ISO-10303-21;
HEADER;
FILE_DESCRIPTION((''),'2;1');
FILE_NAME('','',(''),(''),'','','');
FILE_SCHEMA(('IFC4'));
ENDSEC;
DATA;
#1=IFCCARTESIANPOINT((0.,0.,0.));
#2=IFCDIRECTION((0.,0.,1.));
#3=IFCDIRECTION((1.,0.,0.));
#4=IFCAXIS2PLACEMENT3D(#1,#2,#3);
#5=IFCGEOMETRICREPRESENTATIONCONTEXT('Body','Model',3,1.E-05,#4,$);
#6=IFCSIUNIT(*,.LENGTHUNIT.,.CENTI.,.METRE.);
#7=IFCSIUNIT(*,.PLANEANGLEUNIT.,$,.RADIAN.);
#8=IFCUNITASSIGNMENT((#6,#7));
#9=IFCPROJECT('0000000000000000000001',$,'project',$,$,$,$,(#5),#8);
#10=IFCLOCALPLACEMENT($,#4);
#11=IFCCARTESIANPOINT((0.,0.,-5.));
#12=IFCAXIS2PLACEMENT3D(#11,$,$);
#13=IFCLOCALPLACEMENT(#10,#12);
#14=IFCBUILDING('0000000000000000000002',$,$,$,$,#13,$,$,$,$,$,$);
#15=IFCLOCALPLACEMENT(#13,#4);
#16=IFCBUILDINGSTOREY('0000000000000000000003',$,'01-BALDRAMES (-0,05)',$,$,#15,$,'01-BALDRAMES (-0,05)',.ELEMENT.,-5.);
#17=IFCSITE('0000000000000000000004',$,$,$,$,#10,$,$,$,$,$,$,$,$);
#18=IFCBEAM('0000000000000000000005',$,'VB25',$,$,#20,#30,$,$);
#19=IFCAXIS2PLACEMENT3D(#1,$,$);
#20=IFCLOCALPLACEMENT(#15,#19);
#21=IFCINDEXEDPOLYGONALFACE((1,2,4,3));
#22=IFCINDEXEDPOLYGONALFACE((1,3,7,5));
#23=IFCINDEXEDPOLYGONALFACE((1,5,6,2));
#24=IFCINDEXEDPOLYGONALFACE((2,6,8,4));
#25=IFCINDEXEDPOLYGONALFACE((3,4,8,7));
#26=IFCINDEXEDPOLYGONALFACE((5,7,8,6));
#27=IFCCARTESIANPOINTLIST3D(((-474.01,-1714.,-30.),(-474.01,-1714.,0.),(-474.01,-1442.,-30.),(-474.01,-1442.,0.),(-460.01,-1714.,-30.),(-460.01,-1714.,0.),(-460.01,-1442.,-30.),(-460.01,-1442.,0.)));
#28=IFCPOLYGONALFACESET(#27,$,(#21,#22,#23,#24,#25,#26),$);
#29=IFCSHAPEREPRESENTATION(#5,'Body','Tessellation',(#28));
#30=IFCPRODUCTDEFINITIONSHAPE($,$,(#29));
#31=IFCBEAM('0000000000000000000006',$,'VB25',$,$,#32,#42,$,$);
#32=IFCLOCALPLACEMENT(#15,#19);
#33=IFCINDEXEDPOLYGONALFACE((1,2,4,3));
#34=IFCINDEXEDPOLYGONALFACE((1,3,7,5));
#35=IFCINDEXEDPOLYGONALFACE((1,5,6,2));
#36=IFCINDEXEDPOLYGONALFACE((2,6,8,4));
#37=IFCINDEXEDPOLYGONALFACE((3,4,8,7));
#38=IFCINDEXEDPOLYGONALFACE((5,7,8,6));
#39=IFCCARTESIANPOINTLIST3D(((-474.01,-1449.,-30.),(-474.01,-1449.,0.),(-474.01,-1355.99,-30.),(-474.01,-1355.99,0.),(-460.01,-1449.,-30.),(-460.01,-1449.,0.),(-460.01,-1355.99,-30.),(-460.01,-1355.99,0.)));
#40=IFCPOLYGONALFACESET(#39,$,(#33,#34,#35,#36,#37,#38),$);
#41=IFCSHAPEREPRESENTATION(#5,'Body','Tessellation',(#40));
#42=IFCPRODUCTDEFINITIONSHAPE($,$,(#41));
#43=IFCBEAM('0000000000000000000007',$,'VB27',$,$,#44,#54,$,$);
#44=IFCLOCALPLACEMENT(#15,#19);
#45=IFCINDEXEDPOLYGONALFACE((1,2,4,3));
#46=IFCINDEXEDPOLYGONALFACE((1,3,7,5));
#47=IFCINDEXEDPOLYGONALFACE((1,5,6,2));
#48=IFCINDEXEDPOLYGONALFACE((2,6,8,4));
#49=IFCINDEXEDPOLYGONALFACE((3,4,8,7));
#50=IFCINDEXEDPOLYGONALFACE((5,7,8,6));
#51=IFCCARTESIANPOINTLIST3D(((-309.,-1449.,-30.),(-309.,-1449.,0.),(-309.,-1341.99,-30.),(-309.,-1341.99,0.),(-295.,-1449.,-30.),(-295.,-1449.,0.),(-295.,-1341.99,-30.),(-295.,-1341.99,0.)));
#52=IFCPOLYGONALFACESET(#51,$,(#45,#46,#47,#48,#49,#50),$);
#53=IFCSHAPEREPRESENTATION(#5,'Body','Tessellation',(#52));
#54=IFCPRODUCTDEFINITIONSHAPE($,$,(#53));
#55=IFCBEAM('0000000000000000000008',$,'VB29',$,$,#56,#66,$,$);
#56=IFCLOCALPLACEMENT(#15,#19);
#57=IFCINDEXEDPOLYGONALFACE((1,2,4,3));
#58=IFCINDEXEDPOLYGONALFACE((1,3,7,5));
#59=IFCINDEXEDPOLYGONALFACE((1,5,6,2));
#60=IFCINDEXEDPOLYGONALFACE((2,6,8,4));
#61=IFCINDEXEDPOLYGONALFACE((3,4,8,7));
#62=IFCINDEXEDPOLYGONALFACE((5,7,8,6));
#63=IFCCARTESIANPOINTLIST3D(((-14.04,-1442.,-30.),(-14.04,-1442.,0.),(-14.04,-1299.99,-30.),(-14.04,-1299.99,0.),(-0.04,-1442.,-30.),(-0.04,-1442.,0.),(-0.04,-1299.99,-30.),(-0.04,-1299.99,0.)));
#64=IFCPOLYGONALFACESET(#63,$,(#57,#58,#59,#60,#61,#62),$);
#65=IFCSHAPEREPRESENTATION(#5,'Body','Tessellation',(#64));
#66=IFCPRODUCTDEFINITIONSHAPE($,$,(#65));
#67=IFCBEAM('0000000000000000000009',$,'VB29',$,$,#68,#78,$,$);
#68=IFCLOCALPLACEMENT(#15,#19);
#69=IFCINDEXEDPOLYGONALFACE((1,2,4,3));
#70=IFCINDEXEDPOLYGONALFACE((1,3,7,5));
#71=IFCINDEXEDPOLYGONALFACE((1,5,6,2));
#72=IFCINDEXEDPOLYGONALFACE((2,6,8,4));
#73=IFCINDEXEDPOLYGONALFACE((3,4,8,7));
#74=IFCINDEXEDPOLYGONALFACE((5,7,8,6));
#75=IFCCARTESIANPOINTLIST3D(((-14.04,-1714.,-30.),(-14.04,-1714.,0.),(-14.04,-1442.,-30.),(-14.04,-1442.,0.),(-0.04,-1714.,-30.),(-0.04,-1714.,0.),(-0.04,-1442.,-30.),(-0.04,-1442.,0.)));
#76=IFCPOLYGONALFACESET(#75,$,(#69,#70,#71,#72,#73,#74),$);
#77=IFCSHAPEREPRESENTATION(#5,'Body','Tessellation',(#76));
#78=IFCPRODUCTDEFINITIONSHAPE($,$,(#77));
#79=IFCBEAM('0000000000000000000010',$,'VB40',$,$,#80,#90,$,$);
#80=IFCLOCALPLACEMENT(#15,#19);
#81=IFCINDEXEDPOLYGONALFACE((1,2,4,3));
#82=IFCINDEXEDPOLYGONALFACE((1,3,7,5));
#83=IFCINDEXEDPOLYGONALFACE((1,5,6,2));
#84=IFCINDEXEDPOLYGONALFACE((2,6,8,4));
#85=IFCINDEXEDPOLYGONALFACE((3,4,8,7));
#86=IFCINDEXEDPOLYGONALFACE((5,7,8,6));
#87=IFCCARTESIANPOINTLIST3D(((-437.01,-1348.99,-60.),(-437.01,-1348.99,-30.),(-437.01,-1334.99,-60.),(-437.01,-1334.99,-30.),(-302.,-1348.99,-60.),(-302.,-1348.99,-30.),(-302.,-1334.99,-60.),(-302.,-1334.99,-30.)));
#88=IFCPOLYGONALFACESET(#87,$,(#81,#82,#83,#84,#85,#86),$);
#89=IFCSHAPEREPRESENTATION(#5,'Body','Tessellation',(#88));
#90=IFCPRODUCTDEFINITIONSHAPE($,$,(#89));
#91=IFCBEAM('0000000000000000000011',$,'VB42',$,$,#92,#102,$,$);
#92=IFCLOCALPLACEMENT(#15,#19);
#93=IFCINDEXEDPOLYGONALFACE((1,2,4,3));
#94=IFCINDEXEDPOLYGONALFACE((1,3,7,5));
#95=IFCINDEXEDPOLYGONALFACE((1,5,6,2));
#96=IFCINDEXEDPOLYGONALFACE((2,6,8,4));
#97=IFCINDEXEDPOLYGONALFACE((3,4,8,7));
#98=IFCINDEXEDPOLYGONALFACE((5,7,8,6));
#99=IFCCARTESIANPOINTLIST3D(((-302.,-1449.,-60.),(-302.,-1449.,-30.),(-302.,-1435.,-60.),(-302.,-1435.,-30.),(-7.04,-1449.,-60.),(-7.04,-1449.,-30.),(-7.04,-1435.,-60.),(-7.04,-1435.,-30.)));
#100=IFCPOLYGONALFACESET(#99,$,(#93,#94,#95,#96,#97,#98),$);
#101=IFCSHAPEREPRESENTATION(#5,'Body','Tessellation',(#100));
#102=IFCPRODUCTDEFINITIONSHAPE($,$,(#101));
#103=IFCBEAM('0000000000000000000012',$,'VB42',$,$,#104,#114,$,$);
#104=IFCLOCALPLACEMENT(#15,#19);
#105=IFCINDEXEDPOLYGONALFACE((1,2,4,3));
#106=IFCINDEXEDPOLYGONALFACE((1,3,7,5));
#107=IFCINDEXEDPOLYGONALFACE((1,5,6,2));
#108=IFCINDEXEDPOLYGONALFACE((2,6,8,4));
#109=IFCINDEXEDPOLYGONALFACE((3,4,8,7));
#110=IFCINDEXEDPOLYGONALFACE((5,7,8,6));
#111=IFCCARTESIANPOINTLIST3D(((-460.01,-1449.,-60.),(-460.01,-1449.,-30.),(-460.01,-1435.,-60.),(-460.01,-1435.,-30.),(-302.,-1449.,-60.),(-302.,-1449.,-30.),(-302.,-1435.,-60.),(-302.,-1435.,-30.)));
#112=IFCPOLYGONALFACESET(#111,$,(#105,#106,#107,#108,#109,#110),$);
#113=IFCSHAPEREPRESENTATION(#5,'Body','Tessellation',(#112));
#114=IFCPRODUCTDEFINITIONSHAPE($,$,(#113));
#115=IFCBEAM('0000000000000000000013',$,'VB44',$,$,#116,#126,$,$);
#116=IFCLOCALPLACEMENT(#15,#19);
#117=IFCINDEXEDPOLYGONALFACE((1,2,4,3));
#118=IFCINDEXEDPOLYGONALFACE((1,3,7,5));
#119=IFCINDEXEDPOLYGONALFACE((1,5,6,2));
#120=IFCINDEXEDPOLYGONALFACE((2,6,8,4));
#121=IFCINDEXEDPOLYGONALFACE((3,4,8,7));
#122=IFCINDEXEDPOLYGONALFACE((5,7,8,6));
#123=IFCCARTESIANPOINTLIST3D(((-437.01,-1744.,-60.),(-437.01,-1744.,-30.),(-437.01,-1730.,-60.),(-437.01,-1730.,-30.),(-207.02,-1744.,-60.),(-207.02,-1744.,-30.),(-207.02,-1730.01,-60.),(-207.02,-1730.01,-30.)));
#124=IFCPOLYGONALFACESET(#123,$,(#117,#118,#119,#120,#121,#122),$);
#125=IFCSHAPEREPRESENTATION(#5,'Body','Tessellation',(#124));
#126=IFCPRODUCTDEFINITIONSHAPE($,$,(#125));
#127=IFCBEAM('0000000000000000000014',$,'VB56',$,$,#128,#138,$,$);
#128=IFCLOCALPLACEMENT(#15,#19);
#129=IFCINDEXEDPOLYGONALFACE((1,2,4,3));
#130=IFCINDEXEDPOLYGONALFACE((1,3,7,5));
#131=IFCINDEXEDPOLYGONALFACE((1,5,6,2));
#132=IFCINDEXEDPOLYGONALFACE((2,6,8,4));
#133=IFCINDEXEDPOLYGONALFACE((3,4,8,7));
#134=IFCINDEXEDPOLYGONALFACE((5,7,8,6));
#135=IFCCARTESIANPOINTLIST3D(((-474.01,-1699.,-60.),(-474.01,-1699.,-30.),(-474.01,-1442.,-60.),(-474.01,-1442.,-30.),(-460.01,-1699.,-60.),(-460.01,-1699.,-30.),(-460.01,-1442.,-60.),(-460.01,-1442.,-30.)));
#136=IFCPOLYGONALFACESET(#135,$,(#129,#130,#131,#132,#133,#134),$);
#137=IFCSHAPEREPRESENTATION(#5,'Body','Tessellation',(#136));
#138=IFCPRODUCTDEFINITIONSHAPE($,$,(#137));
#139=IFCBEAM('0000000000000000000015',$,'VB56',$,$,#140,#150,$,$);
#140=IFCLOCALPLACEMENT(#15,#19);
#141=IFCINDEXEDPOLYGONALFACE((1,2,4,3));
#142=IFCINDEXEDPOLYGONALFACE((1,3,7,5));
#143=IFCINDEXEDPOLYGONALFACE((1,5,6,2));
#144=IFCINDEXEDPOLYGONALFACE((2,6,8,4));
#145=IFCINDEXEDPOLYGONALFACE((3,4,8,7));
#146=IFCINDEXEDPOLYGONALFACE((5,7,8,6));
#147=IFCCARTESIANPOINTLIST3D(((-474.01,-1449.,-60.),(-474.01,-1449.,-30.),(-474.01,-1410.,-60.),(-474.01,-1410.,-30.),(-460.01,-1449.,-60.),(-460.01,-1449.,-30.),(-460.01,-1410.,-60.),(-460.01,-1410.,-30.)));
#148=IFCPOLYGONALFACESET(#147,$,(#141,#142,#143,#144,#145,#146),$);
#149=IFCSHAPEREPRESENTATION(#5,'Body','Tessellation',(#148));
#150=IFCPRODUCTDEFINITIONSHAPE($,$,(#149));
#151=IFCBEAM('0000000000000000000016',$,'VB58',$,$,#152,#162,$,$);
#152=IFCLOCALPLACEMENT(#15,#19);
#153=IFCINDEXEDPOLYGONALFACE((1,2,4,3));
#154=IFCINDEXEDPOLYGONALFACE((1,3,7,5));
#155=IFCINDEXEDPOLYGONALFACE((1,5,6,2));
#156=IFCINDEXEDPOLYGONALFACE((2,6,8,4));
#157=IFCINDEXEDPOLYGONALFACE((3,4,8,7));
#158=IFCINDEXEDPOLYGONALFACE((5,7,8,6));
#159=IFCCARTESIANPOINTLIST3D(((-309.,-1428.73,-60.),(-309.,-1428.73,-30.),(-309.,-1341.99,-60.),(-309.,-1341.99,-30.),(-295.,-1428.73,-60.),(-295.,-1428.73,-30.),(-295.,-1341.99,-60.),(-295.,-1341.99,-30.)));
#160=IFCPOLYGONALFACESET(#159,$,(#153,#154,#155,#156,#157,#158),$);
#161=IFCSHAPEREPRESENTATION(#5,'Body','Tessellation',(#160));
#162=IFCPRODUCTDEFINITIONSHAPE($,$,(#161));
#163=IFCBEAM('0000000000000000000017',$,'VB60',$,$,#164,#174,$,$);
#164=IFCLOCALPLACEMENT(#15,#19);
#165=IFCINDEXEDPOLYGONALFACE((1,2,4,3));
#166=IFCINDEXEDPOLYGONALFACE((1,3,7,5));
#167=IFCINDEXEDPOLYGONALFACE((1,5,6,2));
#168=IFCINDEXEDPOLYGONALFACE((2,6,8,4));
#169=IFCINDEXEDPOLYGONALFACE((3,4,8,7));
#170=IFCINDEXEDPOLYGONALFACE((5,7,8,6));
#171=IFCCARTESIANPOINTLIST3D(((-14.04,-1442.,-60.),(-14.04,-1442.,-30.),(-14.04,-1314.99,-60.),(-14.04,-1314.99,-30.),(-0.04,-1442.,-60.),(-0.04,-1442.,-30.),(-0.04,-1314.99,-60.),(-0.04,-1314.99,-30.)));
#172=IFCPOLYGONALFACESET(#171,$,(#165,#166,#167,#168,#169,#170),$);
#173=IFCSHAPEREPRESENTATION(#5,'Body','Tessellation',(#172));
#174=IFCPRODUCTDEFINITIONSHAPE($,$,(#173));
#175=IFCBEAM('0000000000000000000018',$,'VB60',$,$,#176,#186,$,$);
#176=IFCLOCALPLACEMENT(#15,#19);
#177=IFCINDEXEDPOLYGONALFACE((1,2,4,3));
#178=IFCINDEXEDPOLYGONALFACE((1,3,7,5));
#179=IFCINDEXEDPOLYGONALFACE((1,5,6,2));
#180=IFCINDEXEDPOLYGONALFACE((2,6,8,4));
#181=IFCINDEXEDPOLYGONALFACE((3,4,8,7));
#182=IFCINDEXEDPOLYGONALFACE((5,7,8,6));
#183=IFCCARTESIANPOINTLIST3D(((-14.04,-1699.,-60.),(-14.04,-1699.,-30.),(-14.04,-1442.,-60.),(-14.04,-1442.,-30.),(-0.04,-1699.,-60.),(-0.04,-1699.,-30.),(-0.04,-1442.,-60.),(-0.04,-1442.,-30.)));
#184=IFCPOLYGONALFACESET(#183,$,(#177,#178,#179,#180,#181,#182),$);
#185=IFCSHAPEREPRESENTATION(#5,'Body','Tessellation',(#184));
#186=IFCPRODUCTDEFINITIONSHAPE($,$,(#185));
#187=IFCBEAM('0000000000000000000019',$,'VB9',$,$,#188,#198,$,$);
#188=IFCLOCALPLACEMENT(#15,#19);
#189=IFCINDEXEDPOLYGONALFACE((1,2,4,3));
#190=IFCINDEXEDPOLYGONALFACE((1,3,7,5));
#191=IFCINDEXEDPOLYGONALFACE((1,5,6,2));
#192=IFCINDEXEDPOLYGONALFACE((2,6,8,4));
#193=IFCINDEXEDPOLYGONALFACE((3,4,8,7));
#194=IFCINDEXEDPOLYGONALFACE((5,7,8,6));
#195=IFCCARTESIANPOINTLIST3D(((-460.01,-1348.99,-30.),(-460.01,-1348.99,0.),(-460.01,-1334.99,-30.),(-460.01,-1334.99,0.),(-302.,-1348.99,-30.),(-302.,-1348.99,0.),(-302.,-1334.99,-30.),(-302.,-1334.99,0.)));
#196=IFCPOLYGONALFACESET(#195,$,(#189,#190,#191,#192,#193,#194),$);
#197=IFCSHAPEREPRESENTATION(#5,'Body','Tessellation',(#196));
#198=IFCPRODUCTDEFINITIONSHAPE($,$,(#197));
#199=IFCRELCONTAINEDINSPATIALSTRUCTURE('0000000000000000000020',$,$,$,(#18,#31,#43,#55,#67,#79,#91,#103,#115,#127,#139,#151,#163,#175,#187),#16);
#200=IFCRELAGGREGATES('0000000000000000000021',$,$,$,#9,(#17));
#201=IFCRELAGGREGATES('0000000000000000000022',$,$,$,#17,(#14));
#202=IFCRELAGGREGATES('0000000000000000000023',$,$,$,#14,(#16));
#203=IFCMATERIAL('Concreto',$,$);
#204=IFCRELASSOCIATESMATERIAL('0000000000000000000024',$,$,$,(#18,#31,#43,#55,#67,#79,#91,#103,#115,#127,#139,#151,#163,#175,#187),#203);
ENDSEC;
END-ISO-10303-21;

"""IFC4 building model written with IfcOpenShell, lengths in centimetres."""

from ifc_helpers import new_model, si_unit, frame, origin_with_axes, origin_2d_with_axis, place, context, project, spatial, rectangle, extrude, material, element, save


model = new_model("IFC4")

# Units and contexts
model_context = context("Model", 3, precision=1e-05, world=origin_with_axes(), identifier="Body")
ifc_project = project(units=[si_unit("LENGTHUNIT", "METRE", prefix="CENTI"), si_unit("PLANEANGLEUNIT", "RADIAN")], contexts=[model_context])

# Site, building, storey
site_placement = place(None, origin_with_axes())
site = spatial("IfcSite", under=ifc_project, at=site_placement)
building_placement = place(site_placement, frame((0.0, 0.0, -5.0)))
building = spatial("IfcBuilding", under=site, at=building_placement)
storey_placement = place(building_placement, origin_with_axes())
storey = spatial("IfcBuildingStorey", under=building, at=storey_placement, Name="01-BALDRAMES (-0,05)", LongName="01-BALDRAMES (-0,05)", CompositionType="ELEMENT", Elevation=-5.0)

# Shared definitions
ifc_material = material(Name="Concreto")

# Beams
beam_1_placement = place(storey_placement, frame((-467.01, -1578.0, 0.0), z_axis=(0.0, 0.0, 1.0), x_axis=(1.0, 0.0, 0.0)))
element("IfcBeam", 1, at=beam_1_placement, inside=storey, material=ifc_material, Name="VB25", context=model_context, shape_type="SolidModel", body=[
    extrude(rectangle(XDim=14.0, YDim=30.0, at=origin_2d_with_axis()), frame((0.0, -136.0, -15.0), z_axis=(0.0, 1.0, 0.0), x_axis=(1.0, 0.0, 0.0)), (0.0, 0.0, 1.0), 272.0),
])
beam_2_placement = place(storey_placement, frame((-467.01, -1402.49, 0.0), z_axis=(0.0, 0.0, 1.0), x_axis=(1.0, 0.0, 0.0)))
element("IfcBeam", 2, at=beam_2_placement, inside=storey, material=ifc_material, Name="VB25", context=model_context, shape_type="SolidModel", body=[
    extrude(rectangle(XDim=14.0, YDim=30.0, at=origin_2d_with_axis()), frame((0.0, -46.51, -15.0), z_axis=(0.0, 1.0, 0.0), x_axis=(1.0, 0.0, 0.0)), (0.0, 0.0, 1.0), 93.01),
])
beam_3_placement = place(storey_placement, frame((-302.0, -1395.49, 0.0), z_axis=(0.0, 0.0, 1.0), x_axis=(1.0, 0.0, 0.0)))
element("IfcBeam", 3, at=beam_3_placement, inside=storey, material=ifc_material, Name="VB27", context=model_context, shape_type="SolidModel", body=[
    extrude(rectangle(XDim=14.0, YDim=30.0, at=origin_2d_with_axis()), frame((0.0, -53.51, -15.0), z_axis=(0.0, 1.0, 0.0), x_axis=(1.0, 0.0, 0.0)), (0.0, 0.0, 1.0), 107.01),
])
beam_4_placement = place(storey_placement, frame((-7.04, -1370.99, 0.0), z_axis=(0.0, 0.0, 1.0), x_axis=(1.0, 0.0, 0.0)))
element("IfcBeam", 4, at=beam_4_placement, inside=storey, material=ifc_material, Name="VB29", context=model_context, shape_type="SolidModel", body=[
    extrude(rectangle(XDim=14.0, YDim=30.0, at=origin_2d_with_axis()), frame((0.0, -71.0, -15.0), z_axis=(0.0, 1.0, 0.0), x_axis=(1.0, 0.0, 0.0)), (0.0, 0.0, 1.0), 142.01),
])
beam_5_placement = place(storey_placement, frame((-7.04, -1578.0, 0.0), z_axis=(0.0, 0.0, 1.0), x_axis=(1.0, 0.0, 0.0)))
element("IfcBeam", 5, at=beam_5_placement, inside=storey, material=ifc_material, Name="VB29", context=model_context, shape_type="SolidModel", body=[
    extrude(rectangle(XDim=14.0, YDim=30.0, at=origin_2d_with_axis()), frame((0.0, -136.0, -15.0), z_axis=(0.0, 1.0, 0.0), x_axis=(1.0, 0.0, 0.0)), (0.0, 0.0, 1.0), 272.0),
])
beam_6_placement = place(storey_placement, frame((-369.5, -1341.99, -30.0), z_axis=(0.0, 0.0, 1.0), x_axis=(1.0, 0.0, 0.0)))
element("IfcBeam", 6, at=beam_6_placement, inside=storey, material=ifc_material, Name="VB40", context=model_context, shape_type="SolidModel", body=[
    extrude(rectangle(XDim=14.0, YDim=30.0, at=origin_2d_with_axis()), frame((-67.5, 0.0, -15.0), z_axis=(1.0, 0.0, 0.0), x_axis=(0.0, -1.0, 0.0)), (0.0, 0.0, 1.0), 135.01),
])
beam_7_placement = place(storey_placement, frame((-154.52, -1442.0, -30.0), z_axis=(0.0, 0.0, 1.0), x_axis=(1.0, 0.0, 0.0)))
element("IfcBeam", 7, at=beam_7_placement, inside=storey, material=ifc_material, Name="VB42", context=model_context, shape_type="SolidModel", body=[
    extrude(rectangle(XDim=14.0, YDim=30.0, at=origin_2d_with_axis()), frame((-147.48, 0.0, -15.0), z_axis=(1.0, 0.0, 0.0), x_axis=(0.0, -1.0, 0.0)), (0.0, 0.0, 1.0), 294.96),
])
beam_8_placement = place(storey_placement, frame((-381.0, -1442.0, -30.0), z_axis=(0.0, 0.0, 1.0), x_axis=(1.0, 0.0, 0.0)))
element("IfcBeam", 8, at=beam_8_placement, inside=storey, material=ifc_material, Name="VB42", context=model_context, shape_type="SolidModel", body=[
    extrude(rectangle(XDim=14.0, YDim=30.0, at=origin_2d_with_axis()), frame((-79.0, 0.0, -15.0), z_axis=(1.0, 0.0, 0.0), x_axis=(0.0, -1.0, 0.0)), (0.0, 0.0, 1.0), 158.01),
])
beam_9_placement = place(storey_placement, frame((-322.01, -1737.0, -30.0), z_axis=(0.0, 0.0, 1.0), x_axis=(1.0, 0.0, 0.0)))
element("IfcBeam", 9, at=beam_9_placement, inside=storey, material=ifc_material, Name="VB44", context=model_context, shape_type="SolidModel", body=[
    extrude(rectangle(XDim=14.0, YDim=30.0, at=origin_2d_with_axis()), frame((-115.0, 0.0, -15.0), z_axis=(1.0, -0.000022, 0.0), x_axis=(-0.000022, -1.0, 0.0)), (0.0, 0.0, 1.0), 229.99),
])
beam_10_placement = place(storey_placement, frame((-467.01, -1570.5, -30.0), z_axis=(0.0, 0.0, 1.0), x_axis=(1.0, 0.0, 0.0)))
element("IfcBeam", 10, at=beam_10_placement, inside=storey, material=ifc_material, Name="VB56", context=model_context, shape_type="SolidModel", body=[
    extrude(rectangle(XDim=14.0, YDim=30.0, at=origin_2d_with_axis()), frame((0.0, -128.5, -15.0), z_axis=(0.0, 1.0, 0.0), x_axis=(1.0, 0.0, 0.0)), (0.0, 0.0, 1.0), 257.0),
])
beam_11_placement = place(storey_placement, frame((-467.01, -1429.5, -30.0), z_axis=(0.0, 0.0, 1.0), x_axis=(1.0, 0.0, 0.0)))
element("IfcBeam", 11, at=beam_11_placement, inside=storey, material=ifc_material, Name="VB56", context=model_context, shape_type="SolidModel", body=[
    extrude(rectangle(XDim=14.0, YDim=30.0, at=origin_2d_with_axis()), frame((0.0, -19.5, -15.0), z_axis=(0.0, 1.0, 0.0), x_axis=(1.0, 0.0, 0.0)), (0.0, 0.0, 1.0), 39.0),
])
beam_12_placement = place(storey_placement, frame((-302.0, -1385.36, -30.0), z_axis=(0.0, 0.0, 1.0), x_axis=(1.0, 0.0, 0.0)))
element("IfcBeam", 12, at=beam_12_placement, inside=storey, material=ifc_material, Name="VB58", context=model_context, shape_type="SolidModel", body=[
    extrude(rectangle(XDim=14.0, YDim=30.0, at=origin_2d_with_axis()), frame((0.0, -43.37, -15.0), z_axis=(0.0, 1.0, 0.0), x_axis=(1.0, 0.0, 0.0)), (0.0, 0.0, 1.0), 86.74),
])
beam_13_placement = place(storey_placement, frame((-7.04, -1378.49, -30.0), z_axis=(0.0, 0.0, 1.0), x_axis=(1.0, 0.0, 0.0)))
element("IfcBeam", 13, at=beam_13_placement, inside=storey, material=ifc_material, Name="VB60", context=model_context, shape_type="SolidModel", body=[
    extrude(rectangle(XDim=14.0, YDim=30.0, at=origin_2d_with_axis()), frame((0.0, -63.51, -15.0), z_axis=(0.0, 1.0, 0.0), x_axis=(1.0, 0.0, 0.0)), (0.0, 0.0, 1.0), 127.01),
])
beam_14_placement = place(storey_placement, frame((-7.04, -1570.5, -30.0), z_axis=(0.0, 0.0, 1.0), x_axis=(1.0, 0.0, 0.0)))
element("IfcBeam", 14, at=beam_14_placement, inside=storey, material=ifc_material, Name="VB60", context=model_context, shape_type="SolidModel", body=[
    extrude(rectangle(XDim=14.0, YDim=30.0, at=origin_2d_with_axis()), frame((0.0, -128.5, -15.0), z_axis=(0.0, 1.0, 0.0), x_axis=(1.0, 0.0, 0.0)), (0.0, 0.0, 1.0), 257.0),
])
beam_15_placement = place(storey_placement, frame((-381.0, -1341.99, 0.0), z_axis=(0.0, 0.0, 1.0), x_axis=(1.0, 0.0, 0.0)))
element("IfcBeam", 15, at=beam_15_placement, inside=storey, material=ifc_material, Name="VB9", context=model_context, shape_type="SolidModel", body=[
    extrude(rectangle(XDim=14.0, YDim=30.0, at=origin_2d_with_axis()), frame((-79.0, 0.0, -15.0), z_axis=(1.0, 0.0, 0.0), x_axis=(0.0, -1.0, 0.0)), (0.0, 0.0, 1.0), 158.01),
])

save(model, "model.ifc")
